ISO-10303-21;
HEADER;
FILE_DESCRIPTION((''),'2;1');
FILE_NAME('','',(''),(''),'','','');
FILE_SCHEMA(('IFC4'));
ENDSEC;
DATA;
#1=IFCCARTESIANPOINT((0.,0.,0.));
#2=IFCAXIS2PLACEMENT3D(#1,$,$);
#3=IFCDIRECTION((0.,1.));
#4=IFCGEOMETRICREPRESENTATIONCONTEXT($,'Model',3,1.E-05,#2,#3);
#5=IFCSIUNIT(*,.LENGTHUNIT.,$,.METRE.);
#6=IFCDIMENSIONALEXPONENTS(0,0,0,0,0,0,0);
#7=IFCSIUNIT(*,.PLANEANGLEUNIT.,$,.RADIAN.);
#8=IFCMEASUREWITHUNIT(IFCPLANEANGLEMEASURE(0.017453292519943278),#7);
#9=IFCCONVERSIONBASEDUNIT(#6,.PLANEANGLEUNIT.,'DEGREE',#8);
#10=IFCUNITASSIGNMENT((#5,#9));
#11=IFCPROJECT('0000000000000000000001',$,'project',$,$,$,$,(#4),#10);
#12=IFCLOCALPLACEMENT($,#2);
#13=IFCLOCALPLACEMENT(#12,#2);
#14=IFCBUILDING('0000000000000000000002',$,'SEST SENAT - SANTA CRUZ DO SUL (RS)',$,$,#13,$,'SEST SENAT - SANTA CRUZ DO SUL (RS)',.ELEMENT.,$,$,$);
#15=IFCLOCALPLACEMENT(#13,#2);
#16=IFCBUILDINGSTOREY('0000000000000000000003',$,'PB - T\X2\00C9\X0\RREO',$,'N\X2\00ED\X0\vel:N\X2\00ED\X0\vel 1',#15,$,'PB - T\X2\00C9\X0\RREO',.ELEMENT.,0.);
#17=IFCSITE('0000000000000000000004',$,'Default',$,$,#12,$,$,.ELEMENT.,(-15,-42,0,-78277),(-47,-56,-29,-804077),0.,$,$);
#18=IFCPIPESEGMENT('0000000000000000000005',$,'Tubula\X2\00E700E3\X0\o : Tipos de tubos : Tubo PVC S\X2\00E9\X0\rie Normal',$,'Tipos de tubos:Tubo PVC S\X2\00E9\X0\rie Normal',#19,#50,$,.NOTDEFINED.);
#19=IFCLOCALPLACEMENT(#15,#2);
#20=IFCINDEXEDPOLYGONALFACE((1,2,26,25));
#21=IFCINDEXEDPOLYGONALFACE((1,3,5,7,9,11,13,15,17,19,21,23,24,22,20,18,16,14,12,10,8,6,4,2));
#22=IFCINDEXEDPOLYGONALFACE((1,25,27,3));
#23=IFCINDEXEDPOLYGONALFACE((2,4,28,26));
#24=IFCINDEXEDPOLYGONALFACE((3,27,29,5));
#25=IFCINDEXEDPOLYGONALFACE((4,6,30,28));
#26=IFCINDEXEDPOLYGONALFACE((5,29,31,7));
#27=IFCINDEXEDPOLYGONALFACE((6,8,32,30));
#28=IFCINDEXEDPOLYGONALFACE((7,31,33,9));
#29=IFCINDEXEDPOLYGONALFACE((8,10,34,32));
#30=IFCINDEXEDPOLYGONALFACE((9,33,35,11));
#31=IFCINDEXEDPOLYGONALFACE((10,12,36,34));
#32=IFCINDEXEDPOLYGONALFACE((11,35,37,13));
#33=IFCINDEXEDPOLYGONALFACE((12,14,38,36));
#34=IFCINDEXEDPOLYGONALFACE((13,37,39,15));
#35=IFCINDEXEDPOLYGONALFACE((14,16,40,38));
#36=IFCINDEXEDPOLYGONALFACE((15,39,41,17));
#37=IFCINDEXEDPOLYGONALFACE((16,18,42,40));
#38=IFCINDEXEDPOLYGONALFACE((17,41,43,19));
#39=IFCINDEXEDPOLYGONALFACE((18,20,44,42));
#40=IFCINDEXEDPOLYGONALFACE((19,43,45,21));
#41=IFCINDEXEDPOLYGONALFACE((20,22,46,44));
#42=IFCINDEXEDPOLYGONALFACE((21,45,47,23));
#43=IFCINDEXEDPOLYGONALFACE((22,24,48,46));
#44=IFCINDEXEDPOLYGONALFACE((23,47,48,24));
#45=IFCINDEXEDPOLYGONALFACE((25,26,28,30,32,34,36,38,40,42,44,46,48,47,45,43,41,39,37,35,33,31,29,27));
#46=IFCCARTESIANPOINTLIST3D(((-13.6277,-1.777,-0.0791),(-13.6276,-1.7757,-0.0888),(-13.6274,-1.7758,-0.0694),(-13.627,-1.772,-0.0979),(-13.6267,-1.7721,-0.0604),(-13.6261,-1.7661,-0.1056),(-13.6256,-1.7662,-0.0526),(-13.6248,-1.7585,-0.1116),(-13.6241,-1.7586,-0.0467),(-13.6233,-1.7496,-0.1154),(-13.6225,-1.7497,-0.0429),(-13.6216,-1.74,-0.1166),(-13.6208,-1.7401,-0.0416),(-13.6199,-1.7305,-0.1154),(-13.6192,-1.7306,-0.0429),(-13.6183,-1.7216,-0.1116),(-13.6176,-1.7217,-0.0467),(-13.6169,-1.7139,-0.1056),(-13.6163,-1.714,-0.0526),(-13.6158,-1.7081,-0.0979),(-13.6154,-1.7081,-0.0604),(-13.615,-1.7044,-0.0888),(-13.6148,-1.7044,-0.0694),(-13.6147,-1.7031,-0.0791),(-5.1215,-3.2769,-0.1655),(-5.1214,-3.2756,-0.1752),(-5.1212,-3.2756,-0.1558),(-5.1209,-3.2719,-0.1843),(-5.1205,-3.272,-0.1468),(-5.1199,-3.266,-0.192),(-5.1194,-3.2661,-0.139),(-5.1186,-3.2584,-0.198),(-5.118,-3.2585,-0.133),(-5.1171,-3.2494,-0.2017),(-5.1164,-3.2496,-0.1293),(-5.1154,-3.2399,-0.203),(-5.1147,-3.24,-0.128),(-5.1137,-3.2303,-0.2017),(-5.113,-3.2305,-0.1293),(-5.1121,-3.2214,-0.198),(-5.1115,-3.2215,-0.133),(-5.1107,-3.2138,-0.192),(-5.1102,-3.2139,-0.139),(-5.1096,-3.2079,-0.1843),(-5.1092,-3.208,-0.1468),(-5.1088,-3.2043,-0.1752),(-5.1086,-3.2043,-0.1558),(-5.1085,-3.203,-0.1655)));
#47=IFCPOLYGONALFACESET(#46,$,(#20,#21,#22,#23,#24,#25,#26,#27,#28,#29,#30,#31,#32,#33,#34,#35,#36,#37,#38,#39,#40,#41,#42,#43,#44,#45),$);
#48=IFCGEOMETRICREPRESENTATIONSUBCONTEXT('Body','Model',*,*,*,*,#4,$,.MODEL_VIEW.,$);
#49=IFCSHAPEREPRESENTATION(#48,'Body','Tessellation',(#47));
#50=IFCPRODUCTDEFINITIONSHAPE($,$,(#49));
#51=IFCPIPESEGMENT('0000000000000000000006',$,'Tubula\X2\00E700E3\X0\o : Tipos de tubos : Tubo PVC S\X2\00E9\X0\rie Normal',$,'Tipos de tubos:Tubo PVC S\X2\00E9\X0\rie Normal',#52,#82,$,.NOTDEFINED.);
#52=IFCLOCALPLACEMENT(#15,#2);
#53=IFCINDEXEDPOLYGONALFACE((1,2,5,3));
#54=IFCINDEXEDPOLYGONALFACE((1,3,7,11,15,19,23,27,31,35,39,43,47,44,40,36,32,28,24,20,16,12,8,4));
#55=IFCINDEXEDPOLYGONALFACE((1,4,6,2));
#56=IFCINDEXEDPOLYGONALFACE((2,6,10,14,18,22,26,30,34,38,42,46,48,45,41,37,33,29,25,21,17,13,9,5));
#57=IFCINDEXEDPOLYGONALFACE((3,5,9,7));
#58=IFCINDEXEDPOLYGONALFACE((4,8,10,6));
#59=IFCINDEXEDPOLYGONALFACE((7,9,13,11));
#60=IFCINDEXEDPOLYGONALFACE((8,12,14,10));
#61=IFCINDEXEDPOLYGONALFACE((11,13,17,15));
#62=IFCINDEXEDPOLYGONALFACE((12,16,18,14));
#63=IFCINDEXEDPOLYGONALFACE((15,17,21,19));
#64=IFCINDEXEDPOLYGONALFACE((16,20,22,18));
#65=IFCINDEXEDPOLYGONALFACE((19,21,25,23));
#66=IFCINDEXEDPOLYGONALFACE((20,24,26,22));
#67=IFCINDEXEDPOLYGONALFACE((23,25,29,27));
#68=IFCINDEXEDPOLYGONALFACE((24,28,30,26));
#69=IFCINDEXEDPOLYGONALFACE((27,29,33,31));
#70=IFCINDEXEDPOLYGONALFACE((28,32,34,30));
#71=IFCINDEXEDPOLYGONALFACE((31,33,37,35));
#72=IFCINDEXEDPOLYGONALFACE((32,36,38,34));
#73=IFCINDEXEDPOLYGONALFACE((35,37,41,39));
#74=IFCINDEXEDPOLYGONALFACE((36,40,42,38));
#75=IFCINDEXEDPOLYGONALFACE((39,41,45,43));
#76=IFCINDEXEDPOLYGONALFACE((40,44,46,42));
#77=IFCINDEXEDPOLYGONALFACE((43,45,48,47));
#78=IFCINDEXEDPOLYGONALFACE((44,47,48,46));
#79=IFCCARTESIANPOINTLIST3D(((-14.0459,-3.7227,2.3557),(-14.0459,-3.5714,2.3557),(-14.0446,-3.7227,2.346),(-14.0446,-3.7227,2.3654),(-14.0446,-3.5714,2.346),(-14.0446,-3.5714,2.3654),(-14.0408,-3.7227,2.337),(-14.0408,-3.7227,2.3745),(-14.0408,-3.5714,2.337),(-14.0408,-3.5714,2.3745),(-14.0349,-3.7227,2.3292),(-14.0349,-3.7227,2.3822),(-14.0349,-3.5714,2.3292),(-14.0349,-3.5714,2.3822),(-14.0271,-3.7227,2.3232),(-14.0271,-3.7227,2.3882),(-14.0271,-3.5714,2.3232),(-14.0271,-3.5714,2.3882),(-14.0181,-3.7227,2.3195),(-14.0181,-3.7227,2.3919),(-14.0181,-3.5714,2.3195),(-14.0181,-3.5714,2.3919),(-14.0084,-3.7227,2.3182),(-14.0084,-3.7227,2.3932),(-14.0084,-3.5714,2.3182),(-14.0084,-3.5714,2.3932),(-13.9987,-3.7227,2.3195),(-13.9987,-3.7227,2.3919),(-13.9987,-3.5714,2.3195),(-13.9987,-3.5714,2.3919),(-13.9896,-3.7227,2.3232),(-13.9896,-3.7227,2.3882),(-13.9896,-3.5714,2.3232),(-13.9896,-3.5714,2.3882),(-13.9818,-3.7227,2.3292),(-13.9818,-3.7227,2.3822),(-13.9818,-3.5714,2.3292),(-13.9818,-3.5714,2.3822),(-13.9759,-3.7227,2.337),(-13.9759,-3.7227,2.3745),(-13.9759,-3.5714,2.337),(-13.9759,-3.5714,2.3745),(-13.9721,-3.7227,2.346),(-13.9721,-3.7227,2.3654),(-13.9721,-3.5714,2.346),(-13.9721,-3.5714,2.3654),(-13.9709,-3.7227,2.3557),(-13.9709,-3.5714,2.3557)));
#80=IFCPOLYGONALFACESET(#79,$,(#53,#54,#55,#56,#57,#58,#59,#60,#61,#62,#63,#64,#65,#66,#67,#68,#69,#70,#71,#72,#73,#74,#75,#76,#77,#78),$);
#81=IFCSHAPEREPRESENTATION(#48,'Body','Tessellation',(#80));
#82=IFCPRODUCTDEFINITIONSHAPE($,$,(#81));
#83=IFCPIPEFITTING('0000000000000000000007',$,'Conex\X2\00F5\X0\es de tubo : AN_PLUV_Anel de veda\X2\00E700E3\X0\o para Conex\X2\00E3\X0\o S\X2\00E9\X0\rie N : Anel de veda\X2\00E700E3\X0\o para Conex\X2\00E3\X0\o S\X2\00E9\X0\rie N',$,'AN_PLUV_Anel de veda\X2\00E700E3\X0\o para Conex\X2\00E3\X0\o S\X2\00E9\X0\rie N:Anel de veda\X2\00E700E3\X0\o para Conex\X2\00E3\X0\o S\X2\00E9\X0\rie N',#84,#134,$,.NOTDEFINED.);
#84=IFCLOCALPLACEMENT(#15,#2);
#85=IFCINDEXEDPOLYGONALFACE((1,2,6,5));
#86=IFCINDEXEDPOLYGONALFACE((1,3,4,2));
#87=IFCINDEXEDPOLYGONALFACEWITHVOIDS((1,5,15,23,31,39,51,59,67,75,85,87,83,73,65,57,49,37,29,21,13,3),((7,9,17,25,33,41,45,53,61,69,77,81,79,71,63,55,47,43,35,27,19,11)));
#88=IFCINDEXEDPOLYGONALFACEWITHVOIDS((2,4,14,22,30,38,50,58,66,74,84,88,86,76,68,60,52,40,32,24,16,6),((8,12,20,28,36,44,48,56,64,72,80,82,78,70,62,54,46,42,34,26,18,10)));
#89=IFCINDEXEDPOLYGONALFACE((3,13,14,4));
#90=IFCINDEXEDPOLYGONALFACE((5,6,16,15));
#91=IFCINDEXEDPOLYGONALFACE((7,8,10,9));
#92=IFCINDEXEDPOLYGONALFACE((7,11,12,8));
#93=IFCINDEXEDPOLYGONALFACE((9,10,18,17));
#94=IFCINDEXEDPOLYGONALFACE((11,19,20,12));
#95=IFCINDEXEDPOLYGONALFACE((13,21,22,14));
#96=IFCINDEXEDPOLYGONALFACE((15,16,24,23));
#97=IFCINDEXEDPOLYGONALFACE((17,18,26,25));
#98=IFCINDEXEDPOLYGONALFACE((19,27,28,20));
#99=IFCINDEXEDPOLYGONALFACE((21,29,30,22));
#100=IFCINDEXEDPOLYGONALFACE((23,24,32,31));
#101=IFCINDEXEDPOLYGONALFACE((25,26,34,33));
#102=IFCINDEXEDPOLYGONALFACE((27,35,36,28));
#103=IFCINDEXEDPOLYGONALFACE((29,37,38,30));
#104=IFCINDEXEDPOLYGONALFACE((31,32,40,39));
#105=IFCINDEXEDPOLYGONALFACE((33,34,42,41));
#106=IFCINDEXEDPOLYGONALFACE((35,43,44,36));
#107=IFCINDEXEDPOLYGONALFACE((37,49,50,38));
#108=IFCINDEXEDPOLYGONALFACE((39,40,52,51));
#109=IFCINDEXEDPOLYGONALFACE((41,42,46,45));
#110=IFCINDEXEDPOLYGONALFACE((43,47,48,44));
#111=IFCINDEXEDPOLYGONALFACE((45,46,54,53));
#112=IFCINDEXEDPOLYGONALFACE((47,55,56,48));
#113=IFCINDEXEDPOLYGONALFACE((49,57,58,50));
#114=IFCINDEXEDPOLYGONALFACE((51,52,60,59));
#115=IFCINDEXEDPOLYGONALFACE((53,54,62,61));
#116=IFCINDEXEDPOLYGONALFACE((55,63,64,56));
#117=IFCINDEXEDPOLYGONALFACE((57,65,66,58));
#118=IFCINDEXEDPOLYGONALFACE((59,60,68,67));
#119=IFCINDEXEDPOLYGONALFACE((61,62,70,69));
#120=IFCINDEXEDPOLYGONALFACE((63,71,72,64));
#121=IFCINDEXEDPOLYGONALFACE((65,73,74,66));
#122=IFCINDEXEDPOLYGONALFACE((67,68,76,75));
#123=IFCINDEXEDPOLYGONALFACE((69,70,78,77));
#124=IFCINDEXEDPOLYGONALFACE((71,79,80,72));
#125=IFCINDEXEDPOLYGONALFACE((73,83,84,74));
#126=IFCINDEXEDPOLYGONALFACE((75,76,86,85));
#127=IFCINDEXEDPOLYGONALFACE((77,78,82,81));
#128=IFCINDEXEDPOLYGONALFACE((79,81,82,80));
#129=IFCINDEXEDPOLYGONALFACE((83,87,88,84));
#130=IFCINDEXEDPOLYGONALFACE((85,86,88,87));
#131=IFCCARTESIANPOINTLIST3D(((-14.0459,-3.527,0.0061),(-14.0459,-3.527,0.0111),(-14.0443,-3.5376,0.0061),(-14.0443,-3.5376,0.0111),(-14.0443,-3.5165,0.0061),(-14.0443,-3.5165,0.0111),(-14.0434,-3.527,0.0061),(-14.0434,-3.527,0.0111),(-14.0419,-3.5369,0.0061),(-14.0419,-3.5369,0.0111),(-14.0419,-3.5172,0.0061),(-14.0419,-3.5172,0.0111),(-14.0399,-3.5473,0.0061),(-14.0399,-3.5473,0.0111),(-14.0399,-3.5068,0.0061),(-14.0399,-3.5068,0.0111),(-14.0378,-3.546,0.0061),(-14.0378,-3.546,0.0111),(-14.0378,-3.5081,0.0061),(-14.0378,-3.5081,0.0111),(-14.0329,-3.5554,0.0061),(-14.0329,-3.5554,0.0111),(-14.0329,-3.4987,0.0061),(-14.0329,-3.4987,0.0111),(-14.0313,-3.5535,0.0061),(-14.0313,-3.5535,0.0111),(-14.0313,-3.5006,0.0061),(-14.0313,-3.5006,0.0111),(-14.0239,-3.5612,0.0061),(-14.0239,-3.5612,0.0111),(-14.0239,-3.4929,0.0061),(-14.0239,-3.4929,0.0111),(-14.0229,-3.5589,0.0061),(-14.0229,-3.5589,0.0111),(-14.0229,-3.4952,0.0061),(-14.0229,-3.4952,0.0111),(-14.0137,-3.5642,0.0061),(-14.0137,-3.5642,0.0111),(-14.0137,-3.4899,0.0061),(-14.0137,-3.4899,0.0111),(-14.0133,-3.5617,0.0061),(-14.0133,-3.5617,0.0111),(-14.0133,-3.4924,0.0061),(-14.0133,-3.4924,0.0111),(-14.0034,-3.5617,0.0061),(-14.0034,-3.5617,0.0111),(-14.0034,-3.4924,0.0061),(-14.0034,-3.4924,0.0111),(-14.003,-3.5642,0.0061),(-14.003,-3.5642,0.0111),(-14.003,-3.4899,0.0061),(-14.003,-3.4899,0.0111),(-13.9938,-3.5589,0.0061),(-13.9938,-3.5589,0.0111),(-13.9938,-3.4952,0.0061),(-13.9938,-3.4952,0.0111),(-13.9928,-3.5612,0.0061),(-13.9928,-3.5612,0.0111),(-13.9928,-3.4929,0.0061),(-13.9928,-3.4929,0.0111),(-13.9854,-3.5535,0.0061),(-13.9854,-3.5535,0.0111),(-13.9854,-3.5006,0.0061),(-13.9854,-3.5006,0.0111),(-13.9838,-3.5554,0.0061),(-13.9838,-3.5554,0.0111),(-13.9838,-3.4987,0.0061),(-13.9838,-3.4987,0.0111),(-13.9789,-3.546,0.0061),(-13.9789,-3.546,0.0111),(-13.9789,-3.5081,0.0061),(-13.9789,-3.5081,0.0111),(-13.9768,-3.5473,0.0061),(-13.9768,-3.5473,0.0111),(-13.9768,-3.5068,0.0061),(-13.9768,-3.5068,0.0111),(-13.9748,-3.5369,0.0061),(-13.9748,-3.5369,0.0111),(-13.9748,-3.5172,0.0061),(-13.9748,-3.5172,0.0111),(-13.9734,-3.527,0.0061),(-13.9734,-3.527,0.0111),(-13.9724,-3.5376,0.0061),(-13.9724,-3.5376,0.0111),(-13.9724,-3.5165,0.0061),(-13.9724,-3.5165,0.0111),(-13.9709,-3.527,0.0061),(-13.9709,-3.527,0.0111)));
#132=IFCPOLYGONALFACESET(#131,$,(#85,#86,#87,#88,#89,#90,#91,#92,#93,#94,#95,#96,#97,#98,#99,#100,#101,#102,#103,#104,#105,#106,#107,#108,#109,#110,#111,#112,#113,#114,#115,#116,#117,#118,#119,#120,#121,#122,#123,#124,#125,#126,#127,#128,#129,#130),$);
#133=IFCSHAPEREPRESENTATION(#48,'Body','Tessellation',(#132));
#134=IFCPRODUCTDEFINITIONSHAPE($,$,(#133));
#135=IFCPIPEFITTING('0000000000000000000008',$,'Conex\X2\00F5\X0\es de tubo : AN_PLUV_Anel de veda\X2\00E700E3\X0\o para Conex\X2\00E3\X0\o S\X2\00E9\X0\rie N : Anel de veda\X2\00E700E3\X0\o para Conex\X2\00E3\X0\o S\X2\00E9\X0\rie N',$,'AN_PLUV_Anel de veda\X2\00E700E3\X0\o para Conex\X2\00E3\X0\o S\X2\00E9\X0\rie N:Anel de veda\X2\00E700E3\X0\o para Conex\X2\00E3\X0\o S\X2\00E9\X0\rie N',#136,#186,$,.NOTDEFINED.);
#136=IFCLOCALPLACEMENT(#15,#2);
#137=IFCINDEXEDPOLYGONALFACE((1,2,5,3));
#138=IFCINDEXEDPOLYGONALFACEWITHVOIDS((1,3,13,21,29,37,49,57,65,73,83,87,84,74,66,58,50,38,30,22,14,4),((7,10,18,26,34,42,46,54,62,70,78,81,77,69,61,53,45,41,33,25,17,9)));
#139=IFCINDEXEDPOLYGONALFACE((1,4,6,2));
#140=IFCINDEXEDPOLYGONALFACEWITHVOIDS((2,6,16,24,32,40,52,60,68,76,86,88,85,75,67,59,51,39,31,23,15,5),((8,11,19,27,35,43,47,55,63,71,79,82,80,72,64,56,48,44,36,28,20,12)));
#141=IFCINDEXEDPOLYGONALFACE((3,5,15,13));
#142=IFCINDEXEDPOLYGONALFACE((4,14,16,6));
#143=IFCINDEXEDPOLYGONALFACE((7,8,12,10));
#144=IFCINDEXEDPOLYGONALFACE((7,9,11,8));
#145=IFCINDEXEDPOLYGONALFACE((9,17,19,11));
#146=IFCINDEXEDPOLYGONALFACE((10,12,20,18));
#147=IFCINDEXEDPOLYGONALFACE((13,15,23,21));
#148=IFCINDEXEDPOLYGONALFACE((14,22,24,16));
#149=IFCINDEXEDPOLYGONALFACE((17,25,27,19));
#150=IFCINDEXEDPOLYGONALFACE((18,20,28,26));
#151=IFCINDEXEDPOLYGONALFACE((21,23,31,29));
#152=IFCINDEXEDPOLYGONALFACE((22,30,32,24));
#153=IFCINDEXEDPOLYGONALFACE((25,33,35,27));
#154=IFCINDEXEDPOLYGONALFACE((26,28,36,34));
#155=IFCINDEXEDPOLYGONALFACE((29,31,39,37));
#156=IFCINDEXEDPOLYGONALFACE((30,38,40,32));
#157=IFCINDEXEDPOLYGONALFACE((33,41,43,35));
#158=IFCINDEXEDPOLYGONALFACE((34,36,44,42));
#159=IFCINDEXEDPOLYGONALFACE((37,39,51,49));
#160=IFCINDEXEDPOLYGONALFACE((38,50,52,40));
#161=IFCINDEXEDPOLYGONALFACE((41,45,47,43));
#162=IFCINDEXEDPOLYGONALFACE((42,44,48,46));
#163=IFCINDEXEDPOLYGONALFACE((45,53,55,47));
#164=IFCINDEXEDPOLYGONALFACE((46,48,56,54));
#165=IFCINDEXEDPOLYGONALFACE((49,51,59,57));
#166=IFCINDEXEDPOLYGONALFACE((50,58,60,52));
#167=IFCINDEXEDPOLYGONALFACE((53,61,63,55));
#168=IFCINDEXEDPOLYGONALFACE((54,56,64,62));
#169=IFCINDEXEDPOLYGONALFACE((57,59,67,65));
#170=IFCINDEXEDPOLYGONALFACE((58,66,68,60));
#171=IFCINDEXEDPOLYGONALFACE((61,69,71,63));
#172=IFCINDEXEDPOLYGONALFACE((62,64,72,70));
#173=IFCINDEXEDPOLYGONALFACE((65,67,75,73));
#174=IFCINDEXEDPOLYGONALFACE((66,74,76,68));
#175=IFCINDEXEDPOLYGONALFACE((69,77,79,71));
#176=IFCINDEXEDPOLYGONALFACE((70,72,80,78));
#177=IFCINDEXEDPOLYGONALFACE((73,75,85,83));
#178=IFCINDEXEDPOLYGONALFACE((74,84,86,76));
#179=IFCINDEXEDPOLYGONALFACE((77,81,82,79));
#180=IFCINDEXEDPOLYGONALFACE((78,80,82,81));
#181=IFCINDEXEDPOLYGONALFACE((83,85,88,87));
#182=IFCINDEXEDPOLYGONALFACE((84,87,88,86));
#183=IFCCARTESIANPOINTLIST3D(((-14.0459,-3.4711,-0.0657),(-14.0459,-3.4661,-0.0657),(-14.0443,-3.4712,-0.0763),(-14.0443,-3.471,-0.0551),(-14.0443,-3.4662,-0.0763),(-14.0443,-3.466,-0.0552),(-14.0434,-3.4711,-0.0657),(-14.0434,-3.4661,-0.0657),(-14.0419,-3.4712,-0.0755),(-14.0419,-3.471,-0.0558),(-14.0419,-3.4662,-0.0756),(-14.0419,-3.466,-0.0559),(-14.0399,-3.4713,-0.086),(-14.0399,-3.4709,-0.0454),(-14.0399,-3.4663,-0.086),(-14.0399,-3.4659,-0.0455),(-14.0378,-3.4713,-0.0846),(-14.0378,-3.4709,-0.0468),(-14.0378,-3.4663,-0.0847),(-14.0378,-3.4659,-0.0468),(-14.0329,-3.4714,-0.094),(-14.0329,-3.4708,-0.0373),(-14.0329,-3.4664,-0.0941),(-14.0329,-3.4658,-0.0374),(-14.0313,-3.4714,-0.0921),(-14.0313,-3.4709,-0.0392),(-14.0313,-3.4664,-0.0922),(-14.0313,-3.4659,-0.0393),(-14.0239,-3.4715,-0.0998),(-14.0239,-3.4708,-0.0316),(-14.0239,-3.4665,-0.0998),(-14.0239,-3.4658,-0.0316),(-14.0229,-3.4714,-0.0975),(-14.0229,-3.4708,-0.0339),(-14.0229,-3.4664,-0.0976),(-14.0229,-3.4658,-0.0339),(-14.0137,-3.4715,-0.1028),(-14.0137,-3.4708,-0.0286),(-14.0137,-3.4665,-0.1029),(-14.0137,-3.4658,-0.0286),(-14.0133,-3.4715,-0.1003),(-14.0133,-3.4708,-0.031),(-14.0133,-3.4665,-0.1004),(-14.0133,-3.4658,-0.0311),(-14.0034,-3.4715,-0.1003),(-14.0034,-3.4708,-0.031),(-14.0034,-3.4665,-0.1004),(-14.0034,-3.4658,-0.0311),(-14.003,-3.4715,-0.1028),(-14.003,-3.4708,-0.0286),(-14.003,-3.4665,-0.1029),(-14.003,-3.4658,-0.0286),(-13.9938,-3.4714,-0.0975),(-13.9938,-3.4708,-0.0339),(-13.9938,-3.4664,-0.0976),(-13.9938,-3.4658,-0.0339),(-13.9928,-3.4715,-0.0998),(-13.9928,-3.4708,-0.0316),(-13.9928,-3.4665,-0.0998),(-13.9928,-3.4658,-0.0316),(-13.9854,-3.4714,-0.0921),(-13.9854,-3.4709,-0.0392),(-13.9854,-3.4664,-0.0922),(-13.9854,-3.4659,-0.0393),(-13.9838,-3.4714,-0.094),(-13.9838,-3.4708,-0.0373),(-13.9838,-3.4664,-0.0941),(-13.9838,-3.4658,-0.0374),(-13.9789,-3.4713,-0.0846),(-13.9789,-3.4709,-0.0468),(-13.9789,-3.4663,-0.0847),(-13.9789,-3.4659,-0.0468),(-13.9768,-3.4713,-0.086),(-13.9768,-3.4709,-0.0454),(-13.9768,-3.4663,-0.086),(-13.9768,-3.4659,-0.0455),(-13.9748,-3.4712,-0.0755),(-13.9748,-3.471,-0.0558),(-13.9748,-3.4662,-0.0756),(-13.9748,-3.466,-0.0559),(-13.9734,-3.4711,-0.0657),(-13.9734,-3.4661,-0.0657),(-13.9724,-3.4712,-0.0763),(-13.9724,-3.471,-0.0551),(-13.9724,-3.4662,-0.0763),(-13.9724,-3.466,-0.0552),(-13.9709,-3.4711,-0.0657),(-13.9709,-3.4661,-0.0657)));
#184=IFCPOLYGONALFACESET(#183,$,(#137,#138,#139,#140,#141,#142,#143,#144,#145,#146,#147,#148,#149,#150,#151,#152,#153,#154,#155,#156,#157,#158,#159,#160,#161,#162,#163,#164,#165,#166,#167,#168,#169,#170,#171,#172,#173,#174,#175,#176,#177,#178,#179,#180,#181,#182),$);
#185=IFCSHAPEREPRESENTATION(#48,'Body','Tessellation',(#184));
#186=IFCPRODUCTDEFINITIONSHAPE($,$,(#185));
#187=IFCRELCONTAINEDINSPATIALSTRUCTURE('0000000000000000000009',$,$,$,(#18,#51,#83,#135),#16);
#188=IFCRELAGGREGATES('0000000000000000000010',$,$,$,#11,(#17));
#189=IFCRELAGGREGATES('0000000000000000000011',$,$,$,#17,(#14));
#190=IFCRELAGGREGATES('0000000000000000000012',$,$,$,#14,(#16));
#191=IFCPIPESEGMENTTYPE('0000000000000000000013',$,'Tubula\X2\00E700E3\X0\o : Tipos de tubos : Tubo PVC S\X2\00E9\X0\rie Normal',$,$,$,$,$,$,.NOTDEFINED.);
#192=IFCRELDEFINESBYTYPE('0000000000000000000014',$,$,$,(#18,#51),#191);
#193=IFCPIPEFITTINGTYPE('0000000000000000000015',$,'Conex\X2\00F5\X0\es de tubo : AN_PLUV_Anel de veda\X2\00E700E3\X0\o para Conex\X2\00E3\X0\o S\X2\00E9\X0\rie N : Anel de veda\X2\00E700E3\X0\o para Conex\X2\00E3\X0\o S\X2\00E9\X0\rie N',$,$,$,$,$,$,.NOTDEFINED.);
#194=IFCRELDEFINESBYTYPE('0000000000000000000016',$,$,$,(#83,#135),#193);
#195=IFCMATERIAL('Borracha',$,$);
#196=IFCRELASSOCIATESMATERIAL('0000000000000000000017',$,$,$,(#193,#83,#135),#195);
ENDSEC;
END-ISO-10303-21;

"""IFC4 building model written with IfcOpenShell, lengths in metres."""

from ifc_helpers import new_model, entity, si_unit, converted_unit, direction, frame, origin, place, context, subcontext, project, spatial, arc, indexed_curve, outline, extrude, source, transform, mapped, material, type_object, type_shapes, element, save


model = new_model("IFC4")

# Units and contexts
model_context = context("Model", 3, precision=1e-05, world=origin(), true_north=direction((0.0, 1.0)))
body_context = subcontext(model_context, "Body", "Model", "MODEL_VIEW")
ifc_project = project(units=[si_unit("LENGTHUNIT", "METRE"), converted_unit("PLANEANGLEUNIT", "DEGREE", entity("IfcPlaneAngleMeasure", 0.017453292519943278), si_unit("PLANEANGLEUNIT", "RADIAN"), dimensions=[0, 0, 0, 0, 0, 0, 0])], contexts=[model_context])

# Site, building, storey
site_placement = place(None, origin())
site = spatial("IfcSite", under=ifc_project, at=site_placement, Name="Default", CompositionType="ELEMENT", RefLatitude=(-15, -42, 0, -78277), RefLongitude=(-47, -56, -29, -804077), RefElevation=0.0)
building_placement = place(site_placement, origin())
building = spatial("IfcBuilding", under=site, at=building_placement, Name="SEST SENAT - SANTA CRUZ DO SUL (RS)", LongName="SEST SENAT - SANTA CRUZ DO SUL (RS)", CompositionType="ELEMENT")
storey_placement = place(building_placement, origin())
storey = spatial("IfcBuildingStorey", under=building, at=storey_placement, Name="PB - TÉRREO", ObjectType="Nível:Nível 1", LongName="PB - TÉRREO", CompositionType="ELEMENT", Elevation=0.0)

# Shared definitions
ifc_material_1 = material(Name="Borracha")

# Pipe segments
pipe_segment_type_1 = type_object("IfcPipeSegmentType", Name="Tubulação : Tipos de tubos : Tubo PVC Série Normal", PredefinedType="NOTDEFINED")
pipe_segment_1_placement = place(storey_placement, frame((-13.6293, -3.2785, -0.04)))
element("IfcPipeSegment", 1, at=pipe_segment_1_placement, inside=storey, type_object=pipe_segment_type_1, Name="Tubulação : Tipos de tubos : Tubo PVC Série Normal", ObjectType="Tipos de tubos:Tubo PVC Série Normal", PredefinedType="NOTDEFINED", context=body_context, shape_type="SweptSolid", body=[
    extrude(outline(indexed_curve([(0.0375, 0.0), (0.0265, 0.0265), (0.0, 0.0375), (-0.0265, 0.0265), (-0.0375, 0.0), (-0.0265, -0.0265), (0.0, -0.0375), (0.0265, -0.0265)], segments=[arc(1, 2, 3), arc(3, 4, 5), arc(5, 6, 7), arc(7, 8, 1)], self_intersect=False)), frame((8.5143, 0.0385, -0.1255), z_axis=(-0.984759, 0.173639, 0.01), x_axis=(-0.173648, -0.984808, 0.0)), (0.0, 0.0, 1.0), 8.6378),
])
pipe_segment_2_placement = place(storey_placement, frame((-14.0475, -3.7227, 2.3166)))
element("IfcPipeSegment", 2, at=pipe_segment_2_placement, inside=storey, type_object=pipe_segment_type_1, Name="Tubulação : Tipos de tubos : Tubo PVC Série Normal", ObjectType="Tipos de tubos:Tubo PVC Série Normal", PredefinedType="NOTDEFINED", context=body_context, shape_type="SweptSolid", body=[
    extrude(outline(indexed_curve([(0.0375, 0.0), (0.0265, 0.0265), (0.0, 0.0375), (-0.0265, 0.0265), (-0.0375, 0.0), (-0.0265, -0.0265), (0.0, -0.0375), (0.0265, -0.0265)], segments=[arc(1, 2, 3), arc(3, 4, 5), arc(5, 6, 7), arc(7, 8, 1)], self_intersect=False)), frame((0.0391, 0.0, 0.0391), z_axis=(0.0, 1.0, 0.0), x_axis=(-1.0, 0.0, 0.0)), (0.0, 0.0, 1.0), 0.1513),
])

# Pipe fittings
pipe_fitting_type_1 = type_object("IfcPipeFittingType", Name="Conexões de tubo : AN_PLUV_Anel de vedação para Conexão Série N : Anel de vedação para Conexão Série N", PredefinedType="NOTDEFINED", material=ifc_material_1)
shared_shape_1 = source(origin(), body_context, "Body", "SweptSolid", [
    extrude(outline(indexed_curve([(-0.0375, 0.0), (0.0, -0.0375), (0.0375, 0.0), (0.0, 0.0375)], segments=[arc(1, 2, 3), arc(3, 4, 1)], self_intersect=False), holes=[indexed_curve([(-0.035, 0.0), (0.0, 0.035), (0.035, 0.0), (0.0, -0.035)], segments=[arc(1, 2, 3), arc(3, 4, 1)], self_intersect=False)]), frame((0.0, 0.0, -0.005)), (0.0, 0.0, 1.0), 0.005),
])
type_shapes(pipe_fitting_type_1, [shared_shape_1])
pipe_fitting_placement = place(storey_placement, frame((-14.0084, -3.527, 0.0111)))
element("IfcPipeFitting", 3, at=pipe_fitting_placement, inside=storey, type_object=pipe_fitting_type_1, material=ifc_material_1, Name="Conexões de tubo : AN_PLUV_Anel de vedação para Conexão Série N : Anel de vedação para Conexão Série N", ObjectType="AN_PLUV_Anel de vedação para Conexão Série N:Anel de vedação para Conexão Série N", PredefinedType="NOTDEFINED", context=body_context, shape_type="MappedRepresentation", body=[
    mapped(shared_shape_1, transform((0.0, 0.0, 0.0), scale=1.0)),
])
for number, where, z_axis, x_axis, name in (
    (4, (-14.0084, -3.4711, -0.0657), (0.0, -0.99995, 0.01), (1.0, 0.0, 0.0), "Conexões de tubo : AN_PLUV_Anel de vedação para Conexão Série N : Anel de vedação para Conexão Série N"),
):
    element("IfcPipeFitting", number, at=place(storey_placement, frame(where, z_axis=z_axis, x_axis=x_axis)), inside=storey, type_object=pipe_fitting_type_1, material=ifc_material_1, Name=name, ObjectType="AN_PLUV_Anel de vedação para Conexão Série N:Anel de vedação para Conexão Série N", PredefinedType="NOTDEFINED", context=body_context, shape_type="MappedRepresentation", body=[
        mapped(shared_shape_1, transform((0.0, 0.0, 0.0), scale=1.0)),
    ])

save(model, "model.ifc")
